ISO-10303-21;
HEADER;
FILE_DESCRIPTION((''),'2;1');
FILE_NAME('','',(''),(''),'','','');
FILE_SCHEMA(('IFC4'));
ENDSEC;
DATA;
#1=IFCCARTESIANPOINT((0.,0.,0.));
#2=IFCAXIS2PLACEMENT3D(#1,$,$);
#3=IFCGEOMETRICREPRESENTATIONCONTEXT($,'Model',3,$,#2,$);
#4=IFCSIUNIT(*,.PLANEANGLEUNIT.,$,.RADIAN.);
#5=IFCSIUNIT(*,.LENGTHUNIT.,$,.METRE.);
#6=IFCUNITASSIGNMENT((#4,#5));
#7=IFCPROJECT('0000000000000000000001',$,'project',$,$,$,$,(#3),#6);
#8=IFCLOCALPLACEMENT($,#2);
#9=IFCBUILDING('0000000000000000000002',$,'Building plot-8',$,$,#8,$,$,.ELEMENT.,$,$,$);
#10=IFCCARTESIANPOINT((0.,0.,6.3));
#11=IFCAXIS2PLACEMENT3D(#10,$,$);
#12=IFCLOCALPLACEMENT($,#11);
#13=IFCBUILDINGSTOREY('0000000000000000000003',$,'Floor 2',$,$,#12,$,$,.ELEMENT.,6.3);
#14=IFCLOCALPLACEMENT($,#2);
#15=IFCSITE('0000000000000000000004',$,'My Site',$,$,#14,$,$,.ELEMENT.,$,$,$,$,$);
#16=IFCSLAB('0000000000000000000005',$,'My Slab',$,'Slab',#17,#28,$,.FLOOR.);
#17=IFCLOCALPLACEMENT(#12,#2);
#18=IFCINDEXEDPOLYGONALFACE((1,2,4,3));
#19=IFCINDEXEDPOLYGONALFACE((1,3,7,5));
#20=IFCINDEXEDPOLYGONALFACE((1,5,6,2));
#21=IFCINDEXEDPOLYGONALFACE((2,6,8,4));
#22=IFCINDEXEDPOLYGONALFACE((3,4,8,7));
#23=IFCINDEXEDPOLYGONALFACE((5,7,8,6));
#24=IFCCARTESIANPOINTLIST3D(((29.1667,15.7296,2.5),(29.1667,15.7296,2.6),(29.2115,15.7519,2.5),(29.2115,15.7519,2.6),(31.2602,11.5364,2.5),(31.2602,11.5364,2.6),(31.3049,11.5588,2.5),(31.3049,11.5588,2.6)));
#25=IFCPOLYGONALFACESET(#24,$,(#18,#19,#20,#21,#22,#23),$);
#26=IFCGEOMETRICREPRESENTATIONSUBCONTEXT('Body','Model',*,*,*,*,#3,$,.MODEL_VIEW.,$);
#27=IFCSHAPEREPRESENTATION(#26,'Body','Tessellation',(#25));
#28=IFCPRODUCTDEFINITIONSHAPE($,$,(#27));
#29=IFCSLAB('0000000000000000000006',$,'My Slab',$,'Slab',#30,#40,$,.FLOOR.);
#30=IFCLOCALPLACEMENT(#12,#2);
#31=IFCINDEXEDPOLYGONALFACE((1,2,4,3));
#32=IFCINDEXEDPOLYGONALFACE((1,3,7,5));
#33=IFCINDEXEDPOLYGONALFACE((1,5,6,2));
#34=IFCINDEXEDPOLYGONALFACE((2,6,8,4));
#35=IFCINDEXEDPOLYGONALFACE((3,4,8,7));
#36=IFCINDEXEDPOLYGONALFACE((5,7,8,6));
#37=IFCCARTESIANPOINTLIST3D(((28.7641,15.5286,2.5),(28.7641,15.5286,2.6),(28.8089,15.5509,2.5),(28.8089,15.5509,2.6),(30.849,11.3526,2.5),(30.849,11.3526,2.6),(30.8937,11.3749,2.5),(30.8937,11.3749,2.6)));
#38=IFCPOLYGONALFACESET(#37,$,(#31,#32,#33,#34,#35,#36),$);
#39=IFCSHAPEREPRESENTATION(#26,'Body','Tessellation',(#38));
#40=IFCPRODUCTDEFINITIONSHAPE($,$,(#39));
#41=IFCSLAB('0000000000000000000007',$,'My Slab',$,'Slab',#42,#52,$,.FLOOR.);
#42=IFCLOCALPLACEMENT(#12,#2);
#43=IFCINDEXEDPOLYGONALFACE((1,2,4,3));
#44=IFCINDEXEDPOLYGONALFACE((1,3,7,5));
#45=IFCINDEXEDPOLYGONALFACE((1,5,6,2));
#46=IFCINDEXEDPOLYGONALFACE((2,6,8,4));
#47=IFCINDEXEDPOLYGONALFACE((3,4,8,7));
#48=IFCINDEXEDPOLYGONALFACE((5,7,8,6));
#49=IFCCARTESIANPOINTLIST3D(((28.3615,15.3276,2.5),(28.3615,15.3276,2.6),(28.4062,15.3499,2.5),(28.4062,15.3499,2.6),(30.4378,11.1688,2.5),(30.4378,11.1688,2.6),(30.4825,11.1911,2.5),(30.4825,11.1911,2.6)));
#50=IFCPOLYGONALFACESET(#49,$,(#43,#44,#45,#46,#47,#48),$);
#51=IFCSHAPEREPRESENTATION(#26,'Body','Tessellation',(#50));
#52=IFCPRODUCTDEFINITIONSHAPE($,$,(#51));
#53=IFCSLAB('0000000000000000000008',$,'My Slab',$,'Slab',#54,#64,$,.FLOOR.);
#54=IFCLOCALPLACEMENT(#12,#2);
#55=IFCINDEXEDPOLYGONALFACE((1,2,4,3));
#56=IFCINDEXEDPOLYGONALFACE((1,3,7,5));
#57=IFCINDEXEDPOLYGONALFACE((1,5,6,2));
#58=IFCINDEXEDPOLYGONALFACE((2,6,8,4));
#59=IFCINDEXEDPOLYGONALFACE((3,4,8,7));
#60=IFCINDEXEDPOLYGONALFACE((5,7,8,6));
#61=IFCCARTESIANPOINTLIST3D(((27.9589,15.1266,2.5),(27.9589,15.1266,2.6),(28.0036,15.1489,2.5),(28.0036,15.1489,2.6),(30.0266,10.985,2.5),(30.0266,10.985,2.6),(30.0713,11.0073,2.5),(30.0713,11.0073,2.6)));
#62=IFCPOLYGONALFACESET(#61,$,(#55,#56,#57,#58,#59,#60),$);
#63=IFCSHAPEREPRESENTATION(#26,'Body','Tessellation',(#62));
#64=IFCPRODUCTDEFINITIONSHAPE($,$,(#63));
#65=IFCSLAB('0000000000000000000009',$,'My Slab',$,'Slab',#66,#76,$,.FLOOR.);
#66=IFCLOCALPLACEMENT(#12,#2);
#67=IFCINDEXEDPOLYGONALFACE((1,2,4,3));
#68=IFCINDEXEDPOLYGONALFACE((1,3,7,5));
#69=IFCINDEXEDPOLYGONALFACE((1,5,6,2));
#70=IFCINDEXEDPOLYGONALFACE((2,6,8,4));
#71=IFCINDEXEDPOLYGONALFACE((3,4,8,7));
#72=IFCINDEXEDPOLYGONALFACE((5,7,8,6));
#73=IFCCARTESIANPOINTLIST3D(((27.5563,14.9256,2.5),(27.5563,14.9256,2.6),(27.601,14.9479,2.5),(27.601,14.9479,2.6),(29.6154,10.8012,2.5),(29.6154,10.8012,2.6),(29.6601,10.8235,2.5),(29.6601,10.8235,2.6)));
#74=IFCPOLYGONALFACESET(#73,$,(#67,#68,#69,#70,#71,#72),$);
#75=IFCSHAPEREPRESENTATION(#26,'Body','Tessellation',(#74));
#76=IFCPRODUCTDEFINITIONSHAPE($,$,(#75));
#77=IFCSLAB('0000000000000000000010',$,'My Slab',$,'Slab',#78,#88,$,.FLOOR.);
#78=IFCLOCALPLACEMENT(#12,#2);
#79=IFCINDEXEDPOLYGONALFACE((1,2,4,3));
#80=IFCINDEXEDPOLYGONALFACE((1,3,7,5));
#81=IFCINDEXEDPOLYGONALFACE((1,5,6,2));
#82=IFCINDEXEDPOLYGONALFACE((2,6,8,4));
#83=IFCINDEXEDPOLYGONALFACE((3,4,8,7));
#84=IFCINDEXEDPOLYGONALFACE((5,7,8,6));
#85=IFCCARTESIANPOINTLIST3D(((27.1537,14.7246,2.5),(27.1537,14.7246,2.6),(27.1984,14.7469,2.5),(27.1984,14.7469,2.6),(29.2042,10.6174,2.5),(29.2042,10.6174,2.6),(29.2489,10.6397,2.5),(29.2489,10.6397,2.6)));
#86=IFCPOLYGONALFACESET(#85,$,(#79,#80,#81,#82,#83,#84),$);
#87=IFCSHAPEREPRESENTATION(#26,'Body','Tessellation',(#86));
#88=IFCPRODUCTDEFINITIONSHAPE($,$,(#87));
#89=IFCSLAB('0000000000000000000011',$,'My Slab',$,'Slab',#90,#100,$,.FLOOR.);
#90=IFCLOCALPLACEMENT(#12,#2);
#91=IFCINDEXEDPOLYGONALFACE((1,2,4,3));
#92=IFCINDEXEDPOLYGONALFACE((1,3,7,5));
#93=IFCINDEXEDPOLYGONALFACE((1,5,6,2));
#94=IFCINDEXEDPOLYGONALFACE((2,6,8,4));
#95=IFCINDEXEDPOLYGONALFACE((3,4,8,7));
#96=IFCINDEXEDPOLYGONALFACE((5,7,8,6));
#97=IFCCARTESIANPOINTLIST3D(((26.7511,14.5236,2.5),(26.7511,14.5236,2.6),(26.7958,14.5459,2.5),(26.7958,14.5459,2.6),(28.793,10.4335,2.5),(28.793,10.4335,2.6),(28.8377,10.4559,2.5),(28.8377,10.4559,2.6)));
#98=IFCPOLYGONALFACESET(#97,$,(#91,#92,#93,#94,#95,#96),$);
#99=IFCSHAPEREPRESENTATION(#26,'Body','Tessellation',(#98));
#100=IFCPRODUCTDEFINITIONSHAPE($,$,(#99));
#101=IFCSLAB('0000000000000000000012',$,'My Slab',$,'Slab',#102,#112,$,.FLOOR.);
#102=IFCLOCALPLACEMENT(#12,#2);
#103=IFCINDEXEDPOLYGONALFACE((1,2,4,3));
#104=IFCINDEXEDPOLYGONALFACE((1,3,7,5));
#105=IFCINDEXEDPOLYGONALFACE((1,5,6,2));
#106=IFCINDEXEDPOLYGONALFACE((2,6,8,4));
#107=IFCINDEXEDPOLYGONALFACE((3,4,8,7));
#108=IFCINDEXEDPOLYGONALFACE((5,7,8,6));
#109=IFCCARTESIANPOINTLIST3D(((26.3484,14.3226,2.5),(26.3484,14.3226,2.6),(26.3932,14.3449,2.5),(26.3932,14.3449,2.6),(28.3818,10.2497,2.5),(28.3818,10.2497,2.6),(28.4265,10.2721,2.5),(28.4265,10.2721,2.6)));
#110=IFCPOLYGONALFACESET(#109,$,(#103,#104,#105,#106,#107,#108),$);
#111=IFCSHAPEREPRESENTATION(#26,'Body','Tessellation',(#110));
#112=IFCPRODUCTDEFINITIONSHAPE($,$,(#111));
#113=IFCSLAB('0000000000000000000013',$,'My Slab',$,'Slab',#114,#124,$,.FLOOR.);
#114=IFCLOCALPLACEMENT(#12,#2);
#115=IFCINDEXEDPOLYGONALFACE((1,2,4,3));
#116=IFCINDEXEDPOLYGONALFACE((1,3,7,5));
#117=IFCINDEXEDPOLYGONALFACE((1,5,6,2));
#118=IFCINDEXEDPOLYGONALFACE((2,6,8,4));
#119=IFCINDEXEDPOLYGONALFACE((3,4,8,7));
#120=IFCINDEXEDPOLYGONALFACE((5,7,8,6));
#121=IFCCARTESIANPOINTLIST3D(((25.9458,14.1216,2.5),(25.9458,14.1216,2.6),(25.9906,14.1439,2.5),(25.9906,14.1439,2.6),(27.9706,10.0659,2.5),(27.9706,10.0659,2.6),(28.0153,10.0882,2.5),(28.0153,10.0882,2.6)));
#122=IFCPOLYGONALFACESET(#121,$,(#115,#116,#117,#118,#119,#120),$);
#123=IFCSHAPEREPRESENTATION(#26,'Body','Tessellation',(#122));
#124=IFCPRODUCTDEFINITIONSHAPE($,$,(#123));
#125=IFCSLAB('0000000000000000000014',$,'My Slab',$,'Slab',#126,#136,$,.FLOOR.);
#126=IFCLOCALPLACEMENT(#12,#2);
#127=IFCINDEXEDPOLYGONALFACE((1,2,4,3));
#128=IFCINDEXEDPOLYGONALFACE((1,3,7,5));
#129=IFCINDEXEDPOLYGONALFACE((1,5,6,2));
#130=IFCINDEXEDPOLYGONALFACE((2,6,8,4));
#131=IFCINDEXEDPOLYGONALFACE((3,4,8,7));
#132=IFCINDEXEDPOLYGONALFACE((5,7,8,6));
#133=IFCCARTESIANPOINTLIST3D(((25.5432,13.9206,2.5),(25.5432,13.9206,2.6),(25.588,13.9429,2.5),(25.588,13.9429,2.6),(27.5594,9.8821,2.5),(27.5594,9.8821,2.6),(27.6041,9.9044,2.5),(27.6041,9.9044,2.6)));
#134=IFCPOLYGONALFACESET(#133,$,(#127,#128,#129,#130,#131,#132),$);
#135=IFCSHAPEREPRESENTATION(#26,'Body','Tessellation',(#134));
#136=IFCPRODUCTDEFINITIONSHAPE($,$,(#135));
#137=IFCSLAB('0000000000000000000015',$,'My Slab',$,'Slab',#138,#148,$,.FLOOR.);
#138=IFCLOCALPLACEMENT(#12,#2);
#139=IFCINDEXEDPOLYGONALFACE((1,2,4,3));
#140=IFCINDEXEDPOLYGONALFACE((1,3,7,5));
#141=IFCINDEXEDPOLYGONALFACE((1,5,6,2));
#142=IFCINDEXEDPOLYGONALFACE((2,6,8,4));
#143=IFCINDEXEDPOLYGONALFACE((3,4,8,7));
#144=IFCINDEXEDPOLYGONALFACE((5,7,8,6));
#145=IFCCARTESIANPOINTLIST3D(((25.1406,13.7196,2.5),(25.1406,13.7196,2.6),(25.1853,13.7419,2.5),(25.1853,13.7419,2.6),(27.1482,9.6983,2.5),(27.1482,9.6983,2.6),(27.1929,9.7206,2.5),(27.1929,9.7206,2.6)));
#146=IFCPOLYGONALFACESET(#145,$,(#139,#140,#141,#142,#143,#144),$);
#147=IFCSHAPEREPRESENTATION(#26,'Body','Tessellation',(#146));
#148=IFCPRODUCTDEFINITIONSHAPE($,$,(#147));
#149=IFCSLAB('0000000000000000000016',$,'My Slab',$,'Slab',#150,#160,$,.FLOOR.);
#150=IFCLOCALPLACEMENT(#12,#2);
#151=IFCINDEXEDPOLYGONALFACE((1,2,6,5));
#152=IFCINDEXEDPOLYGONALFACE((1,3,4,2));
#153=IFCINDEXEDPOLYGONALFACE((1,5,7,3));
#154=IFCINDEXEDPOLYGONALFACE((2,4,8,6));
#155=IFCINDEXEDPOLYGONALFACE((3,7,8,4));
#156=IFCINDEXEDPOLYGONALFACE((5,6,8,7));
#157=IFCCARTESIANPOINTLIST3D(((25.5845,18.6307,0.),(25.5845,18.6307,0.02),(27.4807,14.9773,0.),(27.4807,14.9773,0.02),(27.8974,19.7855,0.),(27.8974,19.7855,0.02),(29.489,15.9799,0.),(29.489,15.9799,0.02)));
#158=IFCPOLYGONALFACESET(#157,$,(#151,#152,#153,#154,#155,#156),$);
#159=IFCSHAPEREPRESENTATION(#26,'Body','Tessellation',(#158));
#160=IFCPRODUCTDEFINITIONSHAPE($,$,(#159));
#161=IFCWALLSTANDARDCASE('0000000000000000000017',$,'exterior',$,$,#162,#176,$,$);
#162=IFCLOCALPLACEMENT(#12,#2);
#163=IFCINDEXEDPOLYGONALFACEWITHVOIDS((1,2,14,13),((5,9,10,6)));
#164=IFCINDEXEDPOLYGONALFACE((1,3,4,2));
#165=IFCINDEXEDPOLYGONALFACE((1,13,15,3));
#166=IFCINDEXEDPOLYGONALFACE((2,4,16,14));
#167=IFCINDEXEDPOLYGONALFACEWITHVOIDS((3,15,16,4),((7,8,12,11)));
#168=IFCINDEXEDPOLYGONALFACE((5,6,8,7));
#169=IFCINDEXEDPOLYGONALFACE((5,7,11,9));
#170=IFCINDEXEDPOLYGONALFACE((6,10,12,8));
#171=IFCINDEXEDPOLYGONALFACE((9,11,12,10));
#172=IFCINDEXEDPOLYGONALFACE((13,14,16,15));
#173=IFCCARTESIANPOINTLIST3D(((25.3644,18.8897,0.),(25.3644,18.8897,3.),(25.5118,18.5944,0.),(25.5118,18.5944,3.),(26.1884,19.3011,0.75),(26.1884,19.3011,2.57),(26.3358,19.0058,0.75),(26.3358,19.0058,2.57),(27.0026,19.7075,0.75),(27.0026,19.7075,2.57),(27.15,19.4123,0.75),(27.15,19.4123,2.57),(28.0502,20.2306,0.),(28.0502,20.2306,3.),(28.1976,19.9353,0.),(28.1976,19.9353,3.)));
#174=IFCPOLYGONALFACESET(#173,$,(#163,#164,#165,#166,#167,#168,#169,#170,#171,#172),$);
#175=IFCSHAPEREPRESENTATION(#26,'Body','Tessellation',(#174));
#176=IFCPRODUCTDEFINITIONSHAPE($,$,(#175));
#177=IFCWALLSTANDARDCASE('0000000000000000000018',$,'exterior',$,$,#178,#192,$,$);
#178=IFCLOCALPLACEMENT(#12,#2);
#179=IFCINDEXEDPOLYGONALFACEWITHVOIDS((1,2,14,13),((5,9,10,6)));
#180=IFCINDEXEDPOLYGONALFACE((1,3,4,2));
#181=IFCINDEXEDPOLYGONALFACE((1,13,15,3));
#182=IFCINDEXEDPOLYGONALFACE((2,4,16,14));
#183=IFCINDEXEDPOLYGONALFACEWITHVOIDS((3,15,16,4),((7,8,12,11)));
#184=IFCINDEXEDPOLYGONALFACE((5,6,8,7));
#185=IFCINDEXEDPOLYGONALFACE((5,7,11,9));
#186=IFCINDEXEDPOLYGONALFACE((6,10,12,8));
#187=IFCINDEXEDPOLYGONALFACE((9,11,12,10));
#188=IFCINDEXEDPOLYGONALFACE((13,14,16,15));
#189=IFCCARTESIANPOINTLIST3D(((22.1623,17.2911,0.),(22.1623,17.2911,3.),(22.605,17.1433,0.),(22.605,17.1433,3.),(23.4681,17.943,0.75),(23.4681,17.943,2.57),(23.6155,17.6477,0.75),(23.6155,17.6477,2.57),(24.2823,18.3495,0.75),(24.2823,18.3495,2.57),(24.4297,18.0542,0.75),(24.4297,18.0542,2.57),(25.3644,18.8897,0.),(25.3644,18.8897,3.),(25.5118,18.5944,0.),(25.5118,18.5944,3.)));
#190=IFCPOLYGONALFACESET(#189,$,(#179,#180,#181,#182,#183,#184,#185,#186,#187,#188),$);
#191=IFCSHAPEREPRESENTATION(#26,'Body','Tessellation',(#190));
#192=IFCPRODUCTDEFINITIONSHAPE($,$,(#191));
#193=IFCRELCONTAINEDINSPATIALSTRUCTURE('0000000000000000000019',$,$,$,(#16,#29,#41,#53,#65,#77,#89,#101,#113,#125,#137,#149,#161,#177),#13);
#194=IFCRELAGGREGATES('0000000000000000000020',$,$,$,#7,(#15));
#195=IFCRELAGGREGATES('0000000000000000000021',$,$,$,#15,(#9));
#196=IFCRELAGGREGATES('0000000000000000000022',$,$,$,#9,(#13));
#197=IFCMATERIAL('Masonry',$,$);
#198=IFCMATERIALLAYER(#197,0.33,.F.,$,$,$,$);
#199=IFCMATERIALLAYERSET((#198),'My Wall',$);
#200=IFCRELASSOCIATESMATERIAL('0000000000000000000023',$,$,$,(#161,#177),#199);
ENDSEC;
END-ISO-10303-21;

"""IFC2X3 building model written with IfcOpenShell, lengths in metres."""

from ifc_helpers import new_model, si_unit, frame, origin, place, context, subcontext, project, spatial, polyline, outline, extrude, material, layer, layer_set, layer_usage, element, save


model = new_model("IFC2X3")

# Units and contexts
model_context = context("Model", 3, world=origin())
body_context = subcontext(model_context, "Body", "Model", "MODEL_VIEW")
ifc_project = project(units=[si_unit("PLANEANGLEUNIT", "RADIAN"), si_unit("LENGTHUNIT", "METRE")], contexts=[model_context])

# Site, building, storey
site_placement = place(None, origin())
site = spatial("IfcSite", under=ifc_project, at=site_placement, Name="My Site", CompositionType="ELEMENT")
building_placement = place(None, origin())
building = spatial("IfcBuilding", under=site, at=building_placement, Name="Building plot-8", CompositionType="ELEMENT")
storey_placement = place(None, frame((0.0, 0.0, 6.3)))
storey = spatial("IfcBuildingStorey", under=building, at=storey_placement, Name="Floor 2", CompositionType="ELEMENT", Elevation=6.3)

# Slabs
slab_1_placement = place(storey_placement, frame((0.0, 0.0, 2.5)))
element("IfcSlab", 1, at=slab_1_placement, inside=storey, Name="My Slab", ObjectType="Slab", PredefinedType="FLOOR", context=body_context, shape_type="SweptSolid", body=[
    extrude(outline(polyline([(29.2115, 15.7519), (29.1667, 15.7296), (31.2602, 11.5364), (31.3049, 11.5588), (29.2115, 15.7519)])), origin(), (0.0, 0.0, 1.0), 0.1),
])
slab_2_placement = place(storey_placement, frame((0.0, 0.0, 2.5)))
element("IfcSlab", 2, at=slab_2_placement, inside=storey, Name="My Slab", ObjectType="Slab", PredefinedType="FLOOR", context=body_context, shape_type="SweptSolid", body=[
    extrude(outline(polyline([(28.8089, 15.5509), (28.7641, 15.5286), (30.849, 11.3526), (30.8937, 11.3749), (28.8089, 15.5509)])), origin(), (0.0, 0.0, 1.0), 0.1),
])
slab_3_placement = place(storey_placement, frame((0.0, 0.0, 2.5)))
element("IfcSlab", 3, at=slab_3_placement, inside=storey, Name="My Slab", ObjectType="Slab", PredefinedType="FLOOR", context=body_context, shape_type="SweptSolid", body=[
    extrude(outline(polyline([(28.4062, 15.3499), (28.3615, 15.3276), (30.4378, 11.1688), (30.4825, 11.1911), (28.4062, 15.3499)])), origin(), (0.0, 0.0, 1.0), 0.1),
])
slab_4_placement = place(storey_placement, frame((0.0, 0.0, 2.5)))
element("IfcSlab", 4, at=slab_4_placement, inside=storey, Name="My Slab", ObjectType="Slab", PredefinedType="FLOOR", context=body_context, shape_type="SweptSolid", body=[
    extrude(outline(polyline([(28.0036, 15.1489), (27.9589, 15.1266), (30.0266, 10.985), (30.0713, 11.0073), (28.0036, 15.1489)])), origin(), (0.0, 0.0, 1.0), 0.1),
])
slab_5_placement = place(storey_placement, frame((0.0, 0.0, 2.5)))
element("IfcSlab", 5, at=slab_5_placement, inside=storey, Name="My Slab", ObjectType="Slab", PredefinedType="FLOOR", context=body_context, shape_type="SweptSolid", body=[
    extrude(outline(polyline([(27.601, 14.9479), (27.5563, 14.9256), (29.6154, 10.8012), (29.6601, 10.8235), (27.601, 14.9479)])), origin(), (0.0, 0.0, 1.0), 0.1),
])
slab_6_placement = place(storey_placement, frame((0.0, 0.0, 2.5)))
element("IfcSlab", 6, at=slab_6_placement, inside=storey, Name="My Slab", ObjectType="Slab", PredefinedType="FLOOR", context=body_context, shape_type="SweptSolid", body=[
    extrude(outline(polyline([(27.1984, 14.7469), (27.1537, 14.7246), (29.2042, 10.6174), (29.2489, 10.6397), (27.1984, 14.7469)])), origin(), (0.0, 0.0, 1.0), 0.1),
])
slab_7_placement = place(storey_placement, frame((0.0, 0.0, 2.5)))
element("IfcSlab", 7, at=slab_7_placement, inside=storey, Name="My Slab", ObjectType="Slab", PredefinedType="FLOOR", context=body_context, shape_type="SweptSolid", body=[
    extrude(outline(polyline([(26.7958, 14.5459), (26.7511, 14.5236), (28.793, 10.4335), (28.8377, 10.4559), (26.7958, 14.5459)])), origin(), (0.0, 0.0, 1.0), 0.1),
])
slab_8_placement = place(storey_placement, frame((0.0, 0.0, 2.5)))
element("IfcSlab", 8, at=slab_8_placement, inside=storey, Name="My Slab", ObjectType="Slab", PredefinedType="FLOOR", context=body_context, shape_type="SweptSolid", body=[
    extrude(outline(polyline([(26.3932, 14.3449), (26.3484, 14.3226), (28.3818, 10.2497), (28.4265, 10.2721), (26.3932, 14.3449)])), origin(), (0.0, 0.0, 1.0), 0.1),
])
slab_9_placement = place(storey_placement, frame((0.0, 0.0, 2.5)))
element("IfcSlab", 9, at=slab_9_placement, inside=storey, Name="My Slab", ObjectType="Slab", PredefinedType="FLOOR", context=body_context, shape_type="SweptSolid", body=[
    extrude(outline(polyline([(25.9906, 14.1439), (25.9458, 14.1216), (27.9706, 10.0659), (28.0153, 10.0882), (25.9906, 14.1439)])), origin(), (0.0, 0.0, 1.0), 0.1),
])
slab_10_placement = place(storey_placement, frame((0.0, 0.0, 2.5)))
element("IfcSlab", 10, at=slab_10_placement, inside=storey, Name="My Slab", ObjectType="Slab", PredefinedType="FLOOR", context=body_context, shape_type="SweptSolid", body=[
    extrude(outline(polyline([(25.588, 13.9429), (25.5432, 13.9206), (27.5594, 9.8821), (27.6041, 9.9044), (25.588, 13.9429)])), origin(), (0.0, 0.0, 1.0), 0.1),
])
slab_11_placement = place(storey_placement, frame((0.0, 0.0, 2.5)))
element("IfcSlab", 11, at=slab_11_placement, inside=storey, Name="My Slab", ObjectType="Slab", PredefinedType="FLOOR", context=body_context, shape_type="SweptSolid", body=[
    extrude(outline(polyline([(25.1853, 13.7419), (25.1406, 13.7196), (27.1482, 9.6983), (27.1929, 9.7206), (25.1853, 13.7419)])), origin(), (0.0, 0.0, 1.0), 0.1),
])
slab_12_placement = place(storey_placement, origin())
element("IfcSlab", 12, at=slab_12_placement, inside=storey, Name="My Slab", ObjectType="Slab", PredefinedType="FLOOR", context=body_context, shape_type="SweptSolid", body=[
    extrude(outline(polyline([(27.4807, 14.9773), (29.489, 15.9799), (27.8974, 19.7855), (25.5845, 18.6307), (27.4807, 14.9773)])), origin(), (0.0, 0.0, 1.0), 0.02),
])

# Walls, openings
ifc_material_1 = material(Name="Masonry")
ifc_layer_1 = layer(ifc_material_1, 0.33, ventilated=False)
ifc_layer_set_1 = layer_set([ifc_layer_1], Name="My Wall")
ifc_layer_usage_1 = layer_usage(ifc_layer_set_1, "AXIS2", "NEGATIVE", 0.08)
wall_1_placement = place(storey_placement, origin())
wall_1 = element("IfcWallStandardCase", 13, at=wall_1_placement, inside=storey, material=ifc_layer_usage_1, Name="exterior", context=body_context, shape_type="SweptSolid", body=[
    extrude(outline(polyline([(28.1976, 19.9353), (28.0502, 20.2306), (25.3644, 18.8897), (25.5118, 18.5944), (28.1976, 19.9353)])), origin(), (0.0, 0.0, 1.0), 3.0),
])
opening_1_placement = place(storey_placement, frame((0.0, 0.0, 0.75)))
element("IfcOpeningElement", 14, at=opening_1_placement, cuts=wall_1, ObjectType="Opening", context=body_context, shape_type="SweptSolid", body=[
    extrude(outline(polyline([(27.0026, 19.7075), (26.1884, 19.3011), (26.3358, 19.0058), (27.15, 19.4123), (27.0026, 19.7075)])), origin(), (0.0, 0.0, 1.0), 1.82),
])
wall_2_placement = place(storey_placement, origin())
wall_2 = element("IfcWallStandardCase", 15, at=wall_2_placement, inside=storey, material=ifc_layer_usage_1, Name="exterior", context=body_context, shape_type="SweptSolid", body=[
    extrude(outline(polyline([(25.5118, 18.5944), (25.3644, 18.8897), (22.1623, 17.2911), (22.605, 17.1433), (25.5118, 18.5944)])), origin(), (0.0, 0.0, 1.0), 3.0),
])
opening_2_placement = place(storey_placement, frame((0.0, 0.0, 0.75)))
element("IfcOpeningElement", 16, at=opening_2_placement, cuts=wall_2, ObjectType="Opening", context=body_context, shape_type="SweptSolid", body=[
    extrude(outline(polyline([(24.2823, 18.3495), (23.4681, 17.943), (23.6155, 17.6477), (24.4297, 18.0542), (24.2823, 18.3495)])), origin(), (0.0, 0.0, 1.0), 1.82),
])

save(model, "model.ifc")
